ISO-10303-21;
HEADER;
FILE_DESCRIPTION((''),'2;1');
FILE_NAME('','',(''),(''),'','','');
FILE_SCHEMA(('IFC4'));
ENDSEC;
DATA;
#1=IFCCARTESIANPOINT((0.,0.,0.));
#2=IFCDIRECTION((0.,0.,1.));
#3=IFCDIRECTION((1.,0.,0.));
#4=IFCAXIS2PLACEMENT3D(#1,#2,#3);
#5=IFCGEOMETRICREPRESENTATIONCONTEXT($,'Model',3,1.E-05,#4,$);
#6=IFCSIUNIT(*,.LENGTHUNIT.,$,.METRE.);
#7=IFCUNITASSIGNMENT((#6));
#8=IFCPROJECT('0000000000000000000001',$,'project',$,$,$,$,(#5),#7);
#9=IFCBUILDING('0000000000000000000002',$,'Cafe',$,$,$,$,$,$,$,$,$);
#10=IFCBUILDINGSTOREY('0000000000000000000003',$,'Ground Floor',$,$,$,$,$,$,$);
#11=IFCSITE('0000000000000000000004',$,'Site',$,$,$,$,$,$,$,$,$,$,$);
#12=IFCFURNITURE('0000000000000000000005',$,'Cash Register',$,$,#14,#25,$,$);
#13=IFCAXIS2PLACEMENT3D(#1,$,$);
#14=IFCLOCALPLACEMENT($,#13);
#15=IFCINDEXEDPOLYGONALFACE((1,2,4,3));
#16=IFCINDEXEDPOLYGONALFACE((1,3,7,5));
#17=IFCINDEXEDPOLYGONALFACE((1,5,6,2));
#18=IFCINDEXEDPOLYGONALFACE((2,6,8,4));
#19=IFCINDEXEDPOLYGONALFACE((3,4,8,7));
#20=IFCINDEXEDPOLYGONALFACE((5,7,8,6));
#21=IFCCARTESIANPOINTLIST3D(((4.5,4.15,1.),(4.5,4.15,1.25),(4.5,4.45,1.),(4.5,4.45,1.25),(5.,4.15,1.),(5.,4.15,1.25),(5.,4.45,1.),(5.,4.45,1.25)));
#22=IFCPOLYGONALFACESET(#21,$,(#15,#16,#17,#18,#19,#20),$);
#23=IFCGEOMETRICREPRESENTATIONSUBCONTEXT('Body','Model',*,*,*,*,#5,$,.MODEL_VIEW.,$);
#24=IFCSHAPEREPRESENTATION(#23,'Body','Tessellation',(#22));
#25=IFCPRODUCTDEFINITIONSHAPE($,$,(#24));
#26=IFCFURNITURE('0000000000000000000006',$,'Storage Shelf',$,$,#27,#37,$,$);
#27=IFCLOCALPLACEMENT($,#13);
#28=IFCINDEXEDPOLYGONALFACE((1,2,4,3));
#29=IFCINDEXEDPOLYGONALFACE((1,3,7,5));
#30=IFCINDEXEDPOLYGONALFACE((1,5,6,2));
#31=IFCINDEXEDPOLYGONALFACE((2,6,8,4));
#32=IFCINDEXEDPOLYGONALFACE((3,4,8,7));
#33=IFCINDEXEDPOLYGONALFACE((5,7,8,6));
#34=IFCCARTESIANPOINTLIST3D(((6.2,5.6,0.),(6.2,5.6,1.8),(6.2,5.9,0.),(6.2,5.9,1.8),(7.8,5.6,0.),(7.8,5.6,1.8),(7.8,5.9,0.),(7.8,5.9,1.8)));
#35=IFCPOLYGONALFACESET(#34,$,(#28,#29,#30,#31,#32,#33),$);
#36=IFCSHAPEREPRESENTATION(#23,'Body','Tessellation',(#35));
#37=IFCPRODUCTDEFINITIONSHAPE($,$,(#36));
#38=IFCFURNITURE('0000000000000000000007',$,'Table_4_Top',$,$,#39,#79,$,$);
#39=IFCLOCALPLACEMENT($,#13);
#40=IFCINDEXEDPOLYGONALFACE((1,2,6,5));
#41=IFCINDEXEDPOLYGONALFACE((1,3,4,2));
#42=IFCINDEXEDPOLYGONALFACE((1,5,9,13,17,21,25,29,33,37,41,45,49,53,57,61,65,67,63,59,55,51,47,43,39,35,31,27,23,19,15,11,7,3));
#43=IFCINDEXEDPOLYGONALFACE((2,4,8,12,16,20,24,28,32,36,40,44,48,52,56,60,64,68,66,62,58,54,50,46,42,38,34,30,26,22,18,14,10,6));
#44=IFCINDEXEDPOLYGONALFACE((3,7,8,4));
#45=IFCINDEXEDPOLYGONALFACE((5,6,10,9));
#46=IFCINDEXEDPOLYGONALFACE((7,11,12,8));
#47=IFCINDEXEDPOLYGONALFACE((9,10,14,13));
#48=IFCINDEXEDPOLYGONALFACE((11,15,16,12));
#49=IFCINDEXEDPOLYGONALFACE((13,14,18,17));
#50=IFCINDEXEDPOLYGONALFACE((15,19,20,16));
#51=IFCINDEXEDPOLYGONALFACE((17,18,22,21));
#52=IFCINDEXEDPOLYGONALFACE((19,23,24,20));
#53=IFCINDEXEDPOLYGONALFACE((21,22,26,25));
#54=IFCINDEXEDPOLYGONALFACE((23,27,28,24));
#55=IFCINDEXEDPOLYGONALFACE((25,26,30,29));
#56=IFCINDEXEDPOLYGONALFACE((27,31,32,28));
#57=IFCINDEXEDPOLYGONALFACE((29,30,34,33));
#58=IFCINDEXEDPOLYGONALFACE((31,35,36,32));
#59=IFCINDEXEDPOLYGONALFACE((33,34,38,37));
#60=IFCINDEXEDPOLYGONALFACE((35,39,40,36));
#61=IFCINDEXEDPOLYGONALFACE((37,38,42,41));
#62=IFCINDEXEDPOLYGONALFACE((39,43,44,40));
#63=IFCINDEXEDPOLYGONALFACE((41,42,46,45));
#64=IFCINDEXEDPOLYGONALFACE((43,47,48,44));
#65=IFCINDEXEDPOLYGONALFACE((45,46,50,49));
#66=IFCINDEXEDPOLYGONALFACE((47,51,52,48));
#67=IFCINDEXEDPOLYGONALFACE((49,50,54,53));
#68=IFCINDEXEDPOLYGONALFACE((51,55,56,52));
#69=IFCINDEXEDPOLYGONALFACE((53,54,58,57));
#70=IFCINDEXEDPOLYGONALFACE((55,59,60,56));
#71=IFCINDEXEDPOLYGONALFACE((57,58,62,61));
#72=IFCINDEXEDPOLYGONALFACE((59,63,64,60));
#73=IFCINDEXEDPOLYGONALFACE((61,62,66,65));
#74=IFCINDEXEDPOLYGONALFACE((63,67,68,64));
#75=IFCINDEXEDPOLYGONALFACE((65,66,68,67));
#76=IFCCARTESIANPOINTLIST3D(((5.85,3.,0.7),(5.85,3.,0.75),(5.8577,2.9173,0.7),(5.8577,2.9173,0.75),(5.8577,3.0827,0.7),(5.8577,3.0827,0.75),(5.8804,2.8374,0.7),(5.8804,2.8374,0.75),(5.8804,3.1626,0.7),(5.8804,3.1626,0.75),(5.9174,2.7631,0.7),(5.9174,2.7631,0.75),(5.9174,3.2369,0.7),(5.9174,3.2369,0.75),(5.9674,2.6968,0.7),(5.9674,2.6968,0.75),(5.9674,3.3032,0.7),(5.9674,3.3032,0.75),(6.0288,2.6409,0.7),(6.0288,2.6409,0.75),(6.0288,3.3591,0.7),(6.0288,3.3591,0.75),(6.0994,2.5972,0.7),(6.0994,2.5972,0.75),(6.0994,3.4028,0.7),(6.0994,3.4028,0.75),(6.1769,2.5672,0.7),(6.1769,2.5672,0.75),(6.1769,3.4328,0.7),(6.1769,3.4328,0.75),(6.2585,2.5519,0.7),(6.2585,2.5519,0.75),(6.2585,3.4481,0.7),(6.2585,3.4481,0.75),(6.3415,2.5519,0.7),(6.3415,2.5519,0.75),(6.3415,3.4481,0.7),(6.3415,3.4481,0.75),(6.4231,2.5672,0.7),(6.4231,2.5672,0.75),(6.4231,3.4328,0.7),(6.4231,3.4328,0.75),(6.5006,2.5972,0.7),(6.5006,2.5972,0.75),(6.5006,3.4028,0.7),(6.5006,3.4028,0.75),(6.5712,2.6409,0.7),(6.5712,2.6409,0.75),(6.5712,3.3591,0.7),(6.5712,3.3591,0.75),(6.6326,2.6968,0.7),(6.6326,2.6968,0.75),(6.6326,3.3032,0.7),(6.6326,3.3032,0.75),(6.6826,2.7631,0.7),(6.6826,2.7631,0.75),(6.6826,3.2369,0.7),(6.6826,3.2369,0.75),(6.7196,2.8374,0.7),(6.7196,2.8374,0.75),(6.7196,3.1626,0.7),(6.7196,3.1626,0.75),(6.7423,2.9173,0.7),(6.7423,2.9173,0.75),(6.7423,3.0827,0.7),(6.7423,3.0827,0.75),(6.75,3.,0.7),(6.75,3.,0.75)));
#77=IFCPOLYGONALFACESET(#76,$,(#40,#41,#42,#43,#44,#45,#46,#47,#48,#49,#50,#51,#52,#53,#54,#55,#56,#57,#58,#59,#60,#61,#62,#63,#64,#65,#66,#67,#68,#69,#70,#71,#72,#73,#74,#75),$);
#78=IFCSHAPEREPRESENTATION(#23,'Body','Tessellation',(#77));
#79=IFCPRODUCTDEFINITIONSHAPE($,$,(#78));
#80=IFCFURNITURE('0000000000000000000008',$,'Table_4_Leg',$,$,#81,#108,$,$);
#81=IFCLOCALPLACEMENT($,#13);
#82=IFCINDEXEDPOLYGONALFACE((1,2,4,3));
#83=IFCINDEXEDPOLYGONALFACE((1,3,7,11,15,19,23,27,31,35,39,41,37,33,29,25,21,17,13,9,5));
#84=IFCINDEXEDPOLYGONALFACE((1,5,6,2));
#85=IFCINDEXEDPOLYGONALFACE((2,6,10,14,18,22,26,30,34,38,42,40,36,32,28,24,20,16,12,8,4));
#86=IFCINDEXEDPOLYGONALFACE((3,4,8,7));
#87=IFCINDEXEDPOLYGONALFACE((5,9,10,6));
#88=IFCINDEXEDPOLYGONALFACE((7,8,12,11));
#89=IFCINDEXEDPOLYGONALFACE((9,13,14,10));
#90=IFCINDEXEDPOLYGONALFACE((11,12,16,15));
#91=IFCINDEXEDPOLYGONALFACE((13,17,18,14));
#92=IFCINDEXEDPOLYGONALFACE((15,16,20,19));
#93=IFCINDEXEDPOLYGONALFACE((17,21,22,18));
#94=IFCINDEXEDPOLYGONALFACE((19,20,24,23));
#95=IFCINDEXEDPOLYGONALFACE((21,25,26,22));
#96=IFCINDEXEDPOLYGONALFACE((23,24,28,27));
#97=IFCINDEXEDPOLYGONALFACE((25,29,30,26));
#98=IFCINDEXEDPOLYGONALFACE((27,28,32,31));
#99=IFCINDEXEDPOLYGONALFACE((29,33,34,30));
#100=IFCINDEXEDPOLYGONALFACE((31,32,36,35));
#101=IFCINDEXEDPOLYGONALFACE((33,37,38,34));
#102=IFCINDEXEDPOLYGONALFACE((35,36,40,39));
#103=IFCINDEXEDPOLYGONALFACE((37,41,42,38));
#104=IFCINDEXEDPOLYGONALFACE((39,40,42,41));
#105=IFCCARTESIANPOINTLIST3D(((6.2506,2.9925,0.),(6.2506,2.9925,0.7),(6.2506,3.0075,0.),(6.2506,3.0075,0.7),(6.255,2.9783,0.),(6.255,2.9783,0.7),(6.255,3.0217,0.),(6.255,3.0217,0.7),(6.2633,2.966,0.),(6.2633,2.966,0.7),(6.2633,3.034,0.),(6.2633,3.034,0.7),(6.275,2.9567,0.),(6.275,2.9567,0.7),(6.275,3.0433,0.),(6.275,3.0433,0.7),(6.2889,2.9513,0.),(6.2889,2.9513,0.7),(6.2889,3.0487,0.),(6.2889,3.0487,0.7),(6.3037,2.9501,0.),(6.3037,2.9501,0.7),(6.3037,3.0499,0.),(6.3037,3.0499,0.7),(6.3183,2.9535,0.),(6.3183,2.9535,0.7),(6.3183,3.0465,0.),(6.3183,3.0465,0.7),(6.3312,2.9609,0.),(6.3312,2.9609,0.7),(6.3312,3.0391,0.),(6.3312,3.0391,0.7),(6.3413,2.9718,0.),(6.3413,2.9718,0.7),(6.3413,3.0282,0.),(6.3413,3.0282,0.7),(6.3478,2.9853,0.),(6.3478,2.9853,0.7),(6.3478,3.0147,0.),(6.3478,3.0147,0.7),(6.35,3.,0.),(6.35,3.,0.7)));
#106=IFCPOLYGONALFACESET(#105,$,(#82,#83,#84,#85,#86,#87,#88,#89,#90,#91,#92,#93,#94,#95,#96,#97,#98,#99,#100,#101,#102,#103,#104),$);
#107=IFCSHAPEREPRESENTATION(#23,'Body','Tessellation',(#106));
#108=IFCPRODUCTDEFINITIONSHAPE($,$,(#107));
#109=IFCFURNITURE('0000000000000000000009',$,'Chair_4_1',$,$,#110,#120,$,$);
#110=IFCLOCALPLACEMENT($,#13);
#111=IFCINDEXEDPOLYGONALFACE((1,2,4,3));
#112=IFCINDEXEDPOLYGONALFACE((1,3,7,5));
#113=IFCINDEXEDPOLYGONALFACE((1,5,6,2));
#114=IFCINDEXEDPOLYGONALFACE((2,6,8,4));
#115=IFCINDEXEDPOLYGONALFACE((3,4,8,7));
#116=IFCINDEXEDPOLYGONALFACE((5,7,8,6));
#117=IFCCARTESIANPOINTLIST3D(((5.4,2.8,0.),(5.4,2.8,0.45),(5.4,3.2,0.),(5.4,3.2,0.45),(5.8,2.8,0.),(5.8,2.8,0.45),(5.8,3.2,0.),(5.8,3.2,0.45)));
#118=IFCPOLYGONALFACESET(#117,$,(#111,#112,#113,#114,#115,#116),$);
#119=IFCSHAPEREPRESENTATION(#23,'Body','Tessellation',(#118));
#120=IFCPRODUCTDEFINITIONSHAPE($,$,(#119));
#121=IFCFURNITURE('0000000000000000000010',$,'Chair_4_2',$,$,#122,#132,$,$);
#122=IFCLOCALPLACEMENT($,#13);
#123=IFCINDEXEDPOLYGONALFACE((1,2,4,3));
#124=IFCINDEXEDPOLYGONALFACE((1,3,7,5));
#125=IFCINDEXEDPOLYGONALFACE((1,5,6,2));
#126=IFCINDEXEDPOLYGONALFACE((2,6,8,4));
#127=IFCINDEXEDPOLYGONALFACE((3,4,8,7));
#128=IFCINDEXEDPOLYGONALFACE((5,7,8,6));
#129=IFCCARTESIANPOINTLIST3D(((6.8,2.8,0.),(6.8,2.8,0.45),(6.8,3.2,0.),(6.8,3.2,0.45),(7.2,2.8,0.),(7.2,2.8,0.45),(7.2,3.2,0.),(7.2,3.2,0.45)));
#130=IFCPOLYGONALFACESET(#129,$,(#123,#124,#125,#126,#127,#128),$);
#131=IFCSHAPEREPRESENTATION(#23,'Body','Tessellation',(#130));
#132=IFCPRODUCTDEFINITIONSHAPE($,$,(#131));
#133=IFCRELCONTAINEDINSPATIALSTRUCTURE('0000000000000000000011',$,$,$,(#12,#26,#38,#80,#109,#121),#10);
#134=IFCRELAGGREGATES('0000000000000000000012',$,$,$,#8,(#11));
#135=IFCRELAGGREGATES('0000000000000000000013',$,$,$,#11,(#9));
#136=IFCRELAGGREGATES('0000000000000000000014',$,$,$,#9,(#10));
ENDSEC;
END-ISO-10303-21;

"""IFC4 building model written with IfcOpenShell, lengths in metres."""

from ifc_helpers import new_model, si_unit, frame, origin, origin_with_axes, origin_2d, place, context, subcontext, project, spatial, rectangle, circle, extrude, element, save


model = new_model("IFC4")

# Units and contexts
model_context = context("Model", 3, precision=1e-05, world=origin_with_axes())
body_context = subcontext(model_context, "Body", "Model", "MODEL_VIEW")
ifc_project = project(units=[si_unit("LENGTHUNIT", "METRE")], contexts=[model_context])

# Site, building, storey
site = spatial("IfcSite", under=ifc_project, Name="Site")
building = spatial("IfcBuilding", under=site, Name="Cafe")
storey = spatial("IfcBuildingStorey", under=building, Name="Ground Floor")

# Furniture
furniture_1_placement = place(None, frame((4.75, 4.3, 1.0), z_axis=(0.0, 0.0, 1.0), x_axis=(1.0, 0.0, 0.0)))
element("IfcFurniture", 1, at=furniture_1_placement, inside=storey, Name="Cash Register", context=body_context, shape_type="SweptSolid", body=[
    extrude(rectangle(XDim=0.5, YDim=0.3, at=origin_2d()), origin(), (0.0, 0.0, 1.0), 0.25),
])
furniture_2_placement = place(None, frame((7.0, 5.75, 0.0), z_axis=(0.0, 0.0, 1.0), x_axis=(1.0, 0.0, 0.0)))
element("IfcFurniture", 2, at=furniture_2_placement, inside=storey, Name="Storage Shelf", context=body_context, shape_type="SweptSolid", body=[
    extrude(rectangle(XDim=1.6, YDim=0.3, at=origin_2d()), origin(), (0.0, 0.0, 1.0), 1.8),
])
furniture_3_placement = place(None, frame((6.3, 3.0, 0.7), z_axis=(0.0, 0.0, 1.0), x_axis=(1.0, 0.0, 0.0)))
element("IfcFurniture", 3, at=furniture_3_placement, inside=storey, Name="Table_4_Top", context=body_context, shape_type="SweptSolid", body=[
    extrude(circle(Radius=0.45, at=origin_2d()), origin(), (0.0, 0.0, 1.0), 0.05),
])
furniture_4_placement = place(None, frame((6.3, 3.0, 0.0), z_axis=(0.0, 0.0, 1.0), x_axis=(1.0, 0.0, 0.0)))
element("IfcFurniture", 4, at=furniture_4_placement, inside=storey, Name="Table_4_Leg", context=body_context, shape_type="SweptSolid", body=[
    extrude(circle(Radius=0.05, at=origin_2d()), origin(), (0.0, 0.0, 1.0), 0.7),
])
for number, where, z_axis, x_axis, name in (
    (5, (5.6, 3.0, 0.0), (0.0, 0.0, 1.0), (1.0, 0.0, 0.0), "Chair_4_1"),
    (6, (7.0, 3.0, 0.0), (0.0, 0.0, 1.0), (1.0, 0.0, 0.0), "Chair_4_2"),
):
    element("IfcFurniture", number, at=place(None, frame(where, z_axis=z_axis, x_axis=x_axis)), inside=storey, Name=name, context=body_context, shape_type="SweptSolid", body=[
        extrude(rectangle(XDim=0.4, YDim=0.4, at=origin_2d()), origin(), (0.0, 0.0, 1.0), 0.45),
    ])

save(model, "model.ifc")
